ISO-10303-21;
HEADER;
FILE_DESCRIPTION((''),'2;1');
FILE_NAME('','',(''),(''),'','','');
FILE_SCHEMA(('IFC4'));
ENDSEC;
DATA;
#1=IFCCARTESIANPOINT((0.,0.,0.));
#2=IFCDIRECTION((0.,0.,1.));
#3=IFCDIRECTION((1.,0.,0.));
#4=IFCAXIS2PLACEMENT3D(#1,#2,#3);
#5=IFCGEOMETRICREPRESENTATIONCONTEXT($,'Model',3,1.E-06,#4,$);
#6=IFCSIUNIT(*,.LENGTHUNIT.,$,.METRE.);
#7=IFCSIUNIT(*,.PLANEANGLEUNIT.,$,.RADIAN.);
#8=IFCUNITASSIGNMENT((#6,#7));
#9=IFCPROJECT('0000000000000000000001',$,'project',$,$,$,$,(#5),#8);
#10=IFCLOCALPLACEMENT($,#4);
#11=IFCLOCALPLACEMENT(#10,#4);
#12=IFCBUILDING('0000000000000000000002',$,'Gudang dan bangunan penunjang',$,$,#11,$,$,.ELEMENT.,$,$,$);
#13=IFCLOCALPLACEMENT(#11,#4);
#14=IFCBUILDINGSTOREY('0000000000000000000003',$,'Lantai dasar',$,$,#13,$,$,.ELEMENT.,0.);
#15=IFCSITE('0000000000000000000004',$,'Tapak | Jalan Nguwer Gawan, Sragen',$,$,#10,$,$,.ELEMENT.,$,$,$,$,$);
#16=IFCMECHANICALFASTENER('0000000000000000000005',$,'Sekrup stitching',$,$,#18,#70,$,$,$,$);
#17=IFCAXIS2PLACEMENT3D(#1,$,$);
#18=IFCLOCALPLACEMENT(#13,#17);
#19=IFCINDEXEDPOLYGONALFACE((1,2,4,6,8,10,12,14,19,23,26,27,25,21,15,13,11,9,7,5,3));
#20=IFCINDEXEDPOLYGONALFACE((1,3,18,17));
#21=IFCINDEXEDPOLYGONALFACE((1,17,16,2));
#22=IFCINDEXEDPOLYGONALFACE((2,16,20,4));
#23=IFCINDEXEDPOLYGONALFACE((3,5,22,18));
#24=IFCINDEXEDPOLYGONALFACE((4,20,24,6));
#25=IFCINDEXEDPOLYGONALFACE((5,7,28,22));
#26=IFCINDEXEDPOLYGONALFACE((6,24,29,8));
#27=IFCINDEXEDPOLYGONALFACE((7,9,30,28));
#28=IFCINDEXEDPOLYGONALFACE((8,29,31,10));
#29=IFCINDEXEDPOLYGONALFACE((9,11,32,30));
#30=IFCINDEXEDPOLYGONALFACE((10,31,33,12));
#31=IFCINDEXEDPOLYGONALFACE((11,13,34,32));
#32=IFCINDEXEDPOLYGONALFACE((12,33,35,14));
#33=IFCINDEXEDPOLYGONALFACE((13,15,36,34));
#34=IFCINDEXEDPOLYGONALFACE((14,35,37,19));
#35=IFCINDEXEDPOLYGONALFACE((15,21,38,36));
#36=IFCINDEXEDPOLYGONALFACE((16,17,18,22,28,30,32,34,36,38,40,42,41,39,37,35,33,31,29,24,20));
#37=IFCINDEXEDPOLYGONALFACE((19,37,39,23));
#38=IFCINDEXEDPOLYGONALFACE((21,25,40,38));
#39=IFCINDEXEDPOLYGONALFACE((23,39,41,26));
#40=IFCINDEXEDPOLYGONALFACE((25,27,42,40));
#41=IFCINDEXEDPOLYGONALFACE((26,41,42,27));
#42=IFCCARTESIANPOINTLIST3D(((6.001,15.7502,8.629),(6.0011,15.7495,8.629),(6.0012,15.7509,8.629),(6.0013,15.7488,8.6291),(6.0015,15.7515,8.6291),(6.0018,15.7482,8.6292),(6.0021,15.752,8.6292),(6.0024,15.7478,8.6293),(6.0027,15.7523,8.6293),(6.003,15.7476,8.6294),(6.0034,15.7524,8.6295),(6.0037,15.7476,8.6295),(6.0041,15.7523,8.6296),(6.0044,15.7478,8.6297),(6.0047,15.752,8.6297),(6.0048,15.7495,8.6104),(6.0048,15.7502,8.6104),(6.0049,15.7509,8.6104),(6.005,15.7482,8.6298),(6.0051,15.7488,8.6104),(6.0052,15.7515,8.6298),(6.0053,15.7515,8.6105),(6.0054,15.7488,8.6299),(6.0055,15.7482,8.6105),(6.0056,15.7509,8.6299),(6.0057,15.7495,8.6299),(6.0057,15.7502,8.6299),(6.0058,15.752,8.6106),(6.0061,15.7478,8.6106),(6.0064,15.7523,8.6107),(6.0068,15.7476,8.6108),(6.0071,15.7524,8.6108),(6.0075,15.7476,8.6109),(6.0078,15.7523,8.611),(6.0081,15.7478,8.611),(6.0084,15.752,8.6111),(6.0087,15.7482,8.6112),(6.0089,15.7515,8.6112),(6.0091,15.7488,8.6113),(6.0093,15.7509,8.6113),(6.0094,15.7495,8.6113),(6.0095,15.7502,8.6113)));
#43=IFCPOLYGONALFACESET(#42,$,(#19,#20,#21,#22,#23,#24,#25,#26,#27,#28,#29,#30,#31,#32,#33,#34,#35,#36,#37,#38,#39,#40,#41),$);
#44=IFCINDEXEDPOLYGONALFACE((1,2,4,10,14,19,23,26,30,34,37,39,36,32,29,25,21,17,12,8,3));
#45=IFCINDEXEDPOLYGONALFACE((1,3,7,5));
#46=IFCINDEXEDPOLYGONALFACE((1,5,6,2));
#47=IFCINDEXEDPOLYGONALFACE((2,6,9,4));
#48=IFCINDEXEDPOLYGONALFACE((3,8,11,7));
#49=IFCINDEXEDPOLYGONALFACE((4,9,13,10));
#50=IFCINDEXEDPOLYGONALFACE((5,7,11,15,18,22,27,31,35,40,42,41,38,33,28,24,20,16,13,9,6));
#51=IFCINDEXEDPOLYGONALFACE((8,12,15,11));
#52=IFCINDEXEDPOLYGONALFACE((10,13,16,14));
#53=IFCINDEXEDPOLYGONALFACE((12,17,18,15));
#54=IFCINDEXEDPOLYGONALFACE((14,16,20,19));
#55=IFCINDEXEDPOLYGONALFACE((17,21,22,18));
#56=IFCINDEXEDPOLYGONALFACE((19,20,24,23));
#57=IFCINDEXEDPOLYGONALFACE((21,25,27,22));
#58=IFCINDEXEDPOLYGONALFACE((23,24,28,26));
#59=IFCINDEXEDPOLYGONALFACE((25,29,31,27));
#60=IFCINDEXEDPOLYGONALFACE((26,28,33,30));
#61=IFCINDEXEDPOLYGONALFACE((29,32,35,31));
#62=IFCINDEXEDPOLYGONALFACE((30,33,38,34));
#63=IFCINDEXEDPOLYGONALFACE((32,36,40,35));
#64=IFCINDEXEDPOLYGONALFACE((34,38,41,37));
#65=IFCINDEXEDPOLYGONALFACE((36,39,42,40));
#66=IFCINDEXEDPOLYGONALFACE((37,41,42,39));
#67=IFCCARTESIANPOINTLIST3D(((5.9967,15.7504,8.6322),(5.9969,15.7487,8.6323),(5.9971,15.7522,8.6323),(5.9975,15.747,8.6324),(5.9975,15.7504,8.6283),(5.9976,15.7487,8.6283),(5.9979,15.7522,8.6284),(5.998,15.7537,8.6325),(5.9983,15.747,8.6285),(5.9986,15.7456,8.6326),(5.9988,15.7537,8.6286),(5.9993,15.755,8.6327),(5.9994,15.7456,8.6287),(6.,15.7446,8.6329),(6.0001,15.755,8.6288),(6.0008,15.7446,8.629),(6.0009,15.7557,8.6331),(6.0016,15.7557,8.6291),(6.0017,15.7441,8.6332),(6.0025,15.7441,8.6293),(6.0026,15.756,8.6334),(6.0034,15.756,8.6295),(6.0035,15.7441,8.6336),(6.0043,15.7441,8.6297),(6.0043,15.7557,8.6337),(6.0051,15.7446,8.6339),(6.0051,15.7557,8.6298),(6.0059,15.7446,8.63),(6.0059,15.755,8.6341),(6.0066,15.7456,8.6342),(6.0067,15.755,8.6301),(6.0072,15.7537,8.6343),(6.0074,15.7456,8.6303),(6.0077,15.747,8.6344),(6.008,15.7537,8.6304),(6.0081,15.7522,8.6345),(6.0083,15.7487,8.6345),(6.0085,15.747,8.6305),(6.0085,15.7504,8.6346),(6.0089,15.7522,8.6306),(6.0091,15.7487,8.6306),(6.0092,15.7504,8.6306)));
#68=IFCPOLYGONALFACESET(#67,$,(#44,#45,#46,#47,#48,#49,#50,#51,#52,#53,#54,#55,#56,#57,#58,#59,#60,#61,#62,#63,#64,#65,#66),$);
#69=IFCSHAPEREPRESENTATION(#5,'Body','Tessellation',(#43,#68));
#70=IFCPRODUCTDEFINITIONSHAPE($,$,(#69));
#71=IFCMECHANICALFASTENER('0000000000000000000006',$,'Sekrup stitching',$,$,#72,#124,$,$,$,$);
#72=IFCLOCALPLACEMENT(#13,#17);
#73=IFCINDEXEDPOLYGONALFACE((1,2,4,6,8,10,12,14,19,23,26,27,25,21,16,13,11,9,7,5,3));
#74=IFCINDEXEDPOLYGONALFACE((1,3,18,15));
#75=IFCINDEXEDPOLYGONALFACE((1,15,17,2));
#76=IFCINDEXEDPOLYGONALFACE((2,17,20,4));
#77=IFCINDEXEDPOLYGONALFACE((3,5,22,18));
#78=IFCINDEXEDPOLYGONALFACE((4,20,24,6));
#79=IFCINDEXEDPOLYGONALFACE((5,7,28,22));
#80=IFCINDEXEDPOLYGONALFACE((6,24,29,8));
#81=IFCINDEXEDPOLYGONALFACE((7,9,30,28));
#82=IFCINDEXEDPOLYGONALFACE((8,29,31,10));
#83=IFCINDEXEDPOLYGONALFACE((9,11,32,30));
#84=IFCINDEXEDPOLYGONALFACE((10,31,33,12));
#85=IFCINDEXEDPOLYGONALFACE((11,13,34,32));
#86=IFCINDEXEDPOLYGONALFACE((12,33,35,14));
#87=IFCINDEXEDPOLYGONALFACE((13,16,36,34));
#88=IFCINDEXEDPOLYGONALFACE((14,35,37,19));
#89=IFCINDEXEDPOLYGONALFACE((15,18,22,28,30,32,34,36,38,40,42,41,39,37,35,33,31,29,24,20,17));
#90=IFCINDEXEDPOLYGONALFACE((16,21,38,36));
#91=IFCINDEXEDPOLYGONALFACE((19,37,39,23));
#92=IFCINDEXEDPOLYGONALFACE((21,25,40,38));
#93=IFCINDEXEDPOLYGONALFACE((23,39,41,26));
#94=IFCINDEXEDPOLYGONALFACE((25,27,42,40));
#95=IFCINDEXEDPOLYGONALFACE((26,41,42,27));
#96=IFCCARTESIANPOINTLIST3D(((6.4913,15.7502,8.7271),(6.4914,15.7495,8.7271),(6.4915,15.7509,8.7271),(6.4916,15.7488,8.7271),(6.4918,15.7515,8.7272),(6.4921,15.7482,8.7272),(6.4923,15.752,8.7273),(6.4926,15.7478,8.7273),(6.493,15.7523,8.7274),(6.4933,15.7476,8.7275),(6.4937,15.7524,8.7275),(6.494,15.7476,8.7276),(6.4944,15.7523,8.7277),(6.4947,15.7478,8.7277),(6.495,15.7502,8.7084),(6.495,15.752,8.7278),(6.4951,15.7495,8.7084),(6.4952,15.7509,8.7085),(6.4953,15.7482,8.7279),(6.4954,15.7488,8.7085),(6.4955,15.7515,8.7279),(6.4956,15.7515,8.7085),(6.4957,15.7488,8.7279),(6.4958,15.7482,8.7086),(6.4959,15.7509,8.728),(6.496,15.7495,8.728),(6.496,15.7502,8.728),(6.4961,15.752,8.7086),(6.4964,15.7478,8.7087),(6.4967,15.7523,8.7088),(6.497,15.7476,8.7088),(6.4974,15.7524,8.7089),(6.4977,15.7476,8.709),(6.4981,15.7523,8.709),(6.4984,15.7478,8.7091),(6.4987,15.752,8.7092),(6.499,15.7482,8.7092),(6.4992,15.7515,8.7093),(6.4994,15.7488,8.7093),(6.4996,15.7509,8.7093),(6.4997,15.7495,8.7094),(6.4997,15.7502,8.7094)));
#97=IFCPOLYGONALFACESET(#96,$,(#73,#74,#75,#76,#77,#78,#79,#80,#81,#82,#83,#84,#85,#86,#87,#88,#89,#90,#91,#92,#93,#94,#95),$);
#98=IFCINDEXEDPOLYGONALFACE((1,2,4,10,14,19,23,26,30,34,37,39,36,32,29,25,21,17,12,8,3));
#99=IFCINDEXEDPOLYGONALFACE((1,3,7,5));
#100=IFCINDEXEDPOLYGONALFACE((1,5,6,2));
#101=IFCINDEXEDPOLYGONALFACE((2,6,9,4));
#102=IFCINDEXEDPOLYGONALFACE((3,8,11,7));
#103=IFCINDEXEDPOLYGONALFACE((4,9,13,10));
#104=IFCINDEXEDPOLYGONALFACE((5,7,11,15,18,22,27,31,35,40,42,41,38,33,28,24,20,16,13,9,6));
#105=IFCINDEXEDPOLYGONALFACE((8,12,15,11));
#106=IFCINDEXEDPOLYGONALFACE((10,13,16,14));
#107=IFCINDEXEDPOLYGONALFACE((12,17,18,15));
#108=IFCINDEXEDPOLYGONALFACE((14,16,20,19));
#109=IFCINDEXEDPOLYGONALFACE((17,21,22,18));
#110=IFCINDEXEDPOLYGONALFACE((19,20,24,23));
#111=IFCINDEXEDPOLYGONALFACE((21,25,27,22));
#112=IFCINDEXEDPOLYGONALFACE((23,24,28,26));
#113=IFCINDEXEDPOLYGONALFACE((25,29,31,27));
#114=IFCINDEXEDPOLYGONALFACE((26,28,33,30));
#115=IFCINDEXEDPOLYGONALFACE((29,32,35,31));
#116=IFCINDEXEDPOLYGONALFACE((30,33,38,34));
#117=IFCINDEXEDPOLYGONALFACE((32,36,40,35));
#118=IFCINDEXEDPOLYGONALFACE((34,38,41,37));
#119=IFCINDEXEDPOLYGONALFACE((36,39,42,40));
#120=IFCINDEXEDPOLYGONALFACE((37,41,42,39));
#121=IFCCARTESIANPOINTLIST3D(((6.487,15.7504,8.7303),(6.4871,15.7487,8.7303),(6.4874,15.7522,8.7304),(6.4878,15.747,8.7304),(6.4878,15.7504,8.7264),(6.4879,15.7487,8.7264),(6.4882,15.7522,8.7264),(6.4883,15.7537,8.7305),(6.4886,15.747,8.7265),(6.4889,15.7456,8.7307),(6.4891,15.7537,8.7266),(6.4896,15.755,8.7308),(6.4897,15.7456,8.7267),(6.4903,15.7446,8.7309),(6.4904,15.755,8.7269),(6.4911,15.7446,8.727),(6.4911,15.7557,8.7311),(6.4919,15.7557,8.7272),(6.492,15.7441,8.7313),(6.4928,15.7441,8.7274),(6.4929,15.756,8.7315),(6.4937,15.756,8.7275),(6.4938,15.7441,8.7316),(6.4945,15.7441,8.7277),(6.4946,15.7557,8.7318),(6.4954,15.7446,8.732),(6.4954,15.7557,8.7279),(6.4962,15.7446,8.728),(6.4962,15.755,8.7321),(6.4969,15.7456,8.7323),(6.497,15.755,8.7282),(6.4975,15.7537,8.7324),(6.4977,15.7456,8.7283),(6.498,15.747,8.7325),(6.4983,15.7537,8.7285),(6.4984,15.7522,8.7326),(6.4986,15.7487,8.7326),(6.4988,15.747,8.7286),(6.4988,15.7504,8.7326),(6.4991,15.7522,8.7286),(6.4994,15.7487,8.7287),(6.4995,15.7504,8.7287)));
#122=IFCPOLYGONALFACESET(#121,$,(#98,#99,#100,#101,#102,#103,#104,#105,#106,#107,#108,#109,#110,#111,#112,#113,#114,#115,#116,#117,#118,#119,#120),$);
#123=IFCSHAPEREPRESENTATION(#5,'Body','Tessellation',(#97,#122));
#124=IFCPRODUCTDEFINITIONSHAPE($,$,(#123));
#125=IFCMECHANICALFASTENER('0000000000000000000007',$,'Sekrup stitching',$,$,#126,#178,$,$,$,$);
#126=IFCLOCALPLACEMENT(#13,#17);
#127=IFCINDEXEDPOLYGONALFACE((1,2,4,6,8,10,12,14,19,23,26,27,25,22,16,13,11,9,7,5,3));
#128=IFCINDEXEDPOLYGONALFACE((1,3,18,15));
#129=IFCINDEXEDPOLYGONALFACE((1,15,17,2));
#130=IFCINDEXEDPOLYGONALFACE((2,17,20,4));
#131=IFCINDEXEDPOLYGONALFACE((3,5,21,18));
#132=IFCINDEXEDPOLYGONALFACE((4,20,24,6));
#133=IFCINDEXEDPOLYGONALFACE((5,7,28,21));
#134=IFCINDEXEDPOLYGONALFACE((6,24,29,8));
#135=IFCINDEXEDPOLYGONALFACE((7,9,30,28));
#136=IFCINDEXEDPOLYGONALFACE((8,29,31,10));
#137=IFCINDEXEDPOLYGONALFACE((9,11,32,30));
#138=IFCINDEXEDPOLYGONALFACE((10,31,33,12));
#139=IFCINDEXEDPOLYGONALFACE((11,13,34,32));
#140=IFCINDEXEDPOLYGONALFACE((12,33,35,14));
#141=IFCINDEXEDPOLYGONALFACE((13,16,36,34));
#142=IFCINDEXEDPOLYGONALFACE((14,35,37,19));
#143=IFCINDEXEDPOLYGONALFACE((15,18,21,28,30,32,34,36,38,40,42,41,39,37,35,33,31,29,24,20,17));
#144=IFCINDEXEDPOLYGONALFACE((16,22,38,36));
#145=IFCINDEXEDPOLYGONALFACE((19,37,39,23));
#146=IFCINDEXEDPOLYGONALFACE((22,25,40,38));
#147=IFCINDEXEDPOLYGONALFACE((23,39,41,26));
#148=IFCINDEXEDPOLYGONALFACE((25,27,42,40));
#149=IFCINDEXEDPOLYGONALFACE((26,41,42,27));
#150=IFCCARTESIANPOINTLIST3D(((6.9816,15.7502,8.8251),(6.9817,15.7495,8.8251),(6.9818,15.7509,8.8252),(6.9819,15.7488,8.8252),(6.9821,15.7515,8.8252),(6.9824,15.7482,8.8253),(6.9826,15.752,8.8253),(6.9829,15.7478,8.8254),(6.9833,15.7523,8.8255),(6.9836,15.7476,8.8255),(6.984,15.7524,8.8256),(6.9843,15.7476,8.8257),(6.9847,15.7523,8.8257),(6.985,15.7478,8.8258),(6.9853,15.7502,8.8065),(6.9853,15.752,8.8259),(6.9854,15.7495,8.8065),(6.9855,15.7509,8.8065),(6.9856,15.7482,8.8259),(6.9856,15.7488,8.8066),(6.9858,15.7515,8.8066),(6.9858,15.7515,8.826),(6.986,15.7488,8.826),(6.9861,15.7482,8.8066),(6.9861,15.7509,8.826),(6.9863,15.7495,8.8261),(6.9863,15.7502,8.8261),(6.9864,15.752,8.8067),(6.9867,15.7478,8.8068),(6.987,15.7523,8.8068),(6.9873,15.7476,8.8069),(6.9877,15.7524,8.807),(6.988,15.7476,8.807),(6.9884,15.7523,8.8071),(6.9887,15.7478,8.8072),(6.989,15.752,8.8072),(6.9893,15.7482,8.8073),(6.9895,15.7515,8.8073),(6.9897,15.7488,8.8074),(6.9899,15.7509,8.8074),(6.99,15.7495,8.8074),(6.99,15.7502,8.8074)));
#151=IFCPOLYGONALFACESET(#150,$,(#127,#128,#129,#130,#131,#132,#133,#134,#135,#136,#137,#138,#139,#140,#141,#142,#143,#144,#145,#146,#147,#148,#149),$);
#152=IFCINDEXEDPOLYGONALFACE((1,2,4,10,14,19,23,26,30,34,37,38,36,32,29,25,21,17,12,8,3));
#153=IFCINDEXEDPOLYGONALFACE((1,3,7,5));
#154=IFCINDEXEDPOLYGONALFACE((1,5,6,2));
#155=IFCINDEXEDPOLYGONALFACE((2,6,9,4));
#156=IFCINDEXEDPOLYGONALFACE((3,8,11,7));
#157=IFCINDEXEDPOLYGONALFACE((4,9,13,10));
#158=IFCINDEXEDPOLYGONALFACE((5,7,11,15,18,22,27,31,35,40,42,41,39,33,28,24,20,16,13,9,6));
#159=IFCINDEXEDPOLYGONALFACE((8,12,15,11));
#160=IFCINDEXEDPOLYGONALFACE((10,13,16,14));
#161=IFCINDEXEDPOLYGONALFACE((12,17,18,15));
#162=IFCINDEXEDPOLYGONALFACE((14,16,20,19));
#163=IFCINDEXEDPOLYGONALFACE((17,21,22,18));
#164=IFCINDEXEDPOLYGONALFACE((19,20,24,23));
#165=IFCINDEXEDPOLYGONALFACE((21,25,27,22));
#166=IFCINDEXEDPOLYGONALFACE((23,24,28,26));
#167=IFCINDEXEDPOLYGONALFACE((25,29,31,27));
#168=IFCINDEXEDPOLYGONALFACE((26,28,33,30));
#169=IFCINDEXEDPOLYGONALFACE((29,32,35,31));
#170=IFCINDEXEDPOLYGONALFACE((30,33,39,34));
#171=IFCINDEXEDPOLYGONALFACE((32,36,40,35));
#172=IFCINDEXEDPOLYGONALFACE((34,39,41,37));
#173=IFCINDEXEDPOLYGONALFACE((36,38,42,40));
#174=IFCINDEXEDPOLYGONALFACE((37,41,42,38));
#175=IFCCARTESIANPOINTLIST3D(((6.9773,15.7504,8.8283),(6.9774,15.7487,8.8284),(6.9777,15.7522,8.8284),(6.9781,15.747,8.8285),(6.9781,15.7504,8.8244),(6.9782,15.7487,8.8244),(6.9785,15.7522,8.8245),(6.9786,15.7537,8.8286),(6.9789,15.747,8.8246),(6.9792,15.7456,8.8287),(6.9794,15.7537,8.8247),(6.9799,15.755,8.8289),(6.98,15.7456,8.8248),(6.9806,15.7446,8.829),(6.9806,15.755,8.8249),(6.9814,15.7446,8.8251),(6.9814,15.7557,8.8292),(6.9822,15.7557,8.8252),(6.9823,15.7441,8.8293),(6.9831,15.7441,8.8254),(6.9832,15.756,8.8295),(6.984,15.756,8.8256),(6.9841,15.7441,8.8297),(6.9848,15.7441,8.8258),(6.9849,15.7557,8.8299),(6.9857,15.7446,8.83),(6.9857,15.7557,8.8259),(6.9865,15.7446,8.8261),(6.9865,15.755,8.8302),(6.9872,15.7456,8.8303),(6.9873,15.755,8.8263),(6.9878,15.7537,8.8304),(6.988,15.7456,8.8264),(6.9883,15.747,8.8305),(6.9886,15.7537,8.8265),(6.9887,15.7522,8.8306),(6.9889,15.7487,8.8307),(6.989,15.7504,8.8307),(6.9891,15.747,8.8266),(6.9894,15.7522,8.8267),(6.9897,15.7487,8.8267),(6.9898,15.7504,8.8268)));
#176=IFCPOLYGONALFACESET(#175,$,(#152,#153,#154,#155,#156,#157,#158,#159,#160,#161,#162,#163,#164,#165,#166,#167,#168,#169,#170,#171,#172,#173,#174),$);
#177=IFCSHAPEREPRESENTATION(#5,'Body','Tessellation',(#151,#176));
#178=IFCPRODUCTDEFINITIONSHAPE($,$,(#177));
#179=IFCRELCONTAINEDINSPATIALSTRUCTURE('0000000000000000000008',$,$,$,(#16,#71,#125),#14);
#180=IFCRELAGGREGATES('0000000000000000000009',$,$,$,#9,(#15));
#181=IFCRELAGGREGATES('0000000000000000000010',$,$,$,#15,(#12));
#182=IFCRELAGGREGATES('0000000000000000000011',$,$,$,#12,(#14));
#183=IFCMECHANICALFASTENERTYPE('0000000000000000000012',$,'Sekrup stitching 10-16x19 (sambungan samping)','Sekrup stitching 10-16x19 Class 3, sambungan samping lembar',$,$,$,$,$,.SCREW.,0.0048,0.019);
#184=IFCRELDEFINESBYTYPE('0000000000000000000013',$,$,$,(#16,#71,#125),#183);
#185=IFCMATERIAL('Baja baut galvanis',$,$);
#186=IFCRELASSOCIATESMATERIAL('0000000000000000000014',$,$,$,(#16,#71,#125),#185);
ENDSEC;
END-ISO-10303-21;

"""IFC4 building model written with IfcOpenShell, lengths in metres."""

from ifc_helpers import new_model, si_unit, frame, origin_with_axes, place, context, project, spatial, circle, extrude, source, transform, mapped, material, type_object, type_shapes, element, save


model = new_model("IFC4")

# Units and contexts
model_context = context("Model", 3, precision=1e-06, world=origin_with_axes())
ifc_project = project(units=[si_unit("LENGTHUNIT", "METRE"), si_unit("PLANEANGLEUNIT", "RADIAN")], contexts=[model_context])

# Site, building, storey
site_placement = place(None, origin_with_axes())
site = spatial("IfcSite", under=ifc_project, at=site_placement, Name="Tapak | Jalan Nguwer Gawan, Sragen", CompositionType="ELEMENT")
building_placement = place(site_placement, origin_with_axes())
building = spatial("IfcBuilding", under=site, at=building_placement, Name="Gudang dan bangunan penunjang", CompositionType="ELEMENT")
storey_placement = place(building_placement, origin_with_axes())
storey = spatial("IfcBuildingStorey", under=building, at=storey_placement, Name="Lantai dasar", CompositionType="ELEMENT", Elevation=0.0)

# Shared definitions
placement = place(None, origin_with_axes())

# Mechanical fasteners
ifc_material_1 = material(Name="Baja baut galvanis")
mechanical_fastener_type_1 = type_object("IfcMechanicalFastenerType", Name="Sekrup stitching 10-16x19 (sambungan samping)", Description="Sekrup stitching 10-16x19 Class 3, sambungan samping lembar", NominalDiameter=0.0048, NominalLength=0.019, PredefinedType="SCREW")
shared_shape_1 = source(origin_with_axes(), model_context, "Body", "SweptSolid", [
    extrude(circle(Radius=0.0024), origin_with_axes(), (0.0, 0.0, 1.0), 0.019),
    extrude(circle(Radius=0.006), frame((0.0, 0.0, -0.004), z_axis=(0.0, 0.0, 1.0), x_axis=(1.0, 0.0, 0.0)), (0.0, 0.0, 1.0), 0.004),
])
type_shapes(mechanical_fastener_type_1, [shared_shape_1])
element("IfcMechanicalFastener", 1, at=placement, inside=storey, type_object=mechanical_fastener_type_1, material=ifc_material_1, Name="Sekrup stitching", context=model_context, shape_type="MappedRepresentation", body=[
    mapped(shared_shape_1, transform((6.0034, 15.75, 8.6295), x_axis=(0.0, 1.0, 0.0), y_axis=(0.980581, 0.0, 0.196116), z_axis=(0.196116, 0.0, -0.980581), scale=1.0)),
])
element("IfcMechanicalFastener", 2, at=placement, inside=storey, type_object=mechanical_fastener_type_1, material=ifc_material_1, Name="Sekrup stitching", context=model_context, shape_type="MappedRepresentation", body=[
    mapped(shared_shape_1, transform((6.4937, 15.75, 8.7275), x_axis=(0.0, 1.0, 0.0), y_axis=(0.980581, 0.0, 0.196116), z_axis=(0.196116, 0.0, -0.980581), scale=1.0)),
])
element("IfcMechanicalFastener", 3, at=placement, inside=storey, type_object=mechanical_fastener_type_1, material=ifc_material_1, Name="Sekrup stitching", context=model_context, shape_type="MappedRepresentation", body=[
    mapped(shared_shape_1, transform((6.984, 15.75, 8.8256), x_axis=(0.0, 1.0, 0.0), y_axis=(0.980581, 0.0, 0.196116), z_axis=(0.196116, 0.0, -0.980581), scale=1.0)),
])

save(model, "model.ifc")
